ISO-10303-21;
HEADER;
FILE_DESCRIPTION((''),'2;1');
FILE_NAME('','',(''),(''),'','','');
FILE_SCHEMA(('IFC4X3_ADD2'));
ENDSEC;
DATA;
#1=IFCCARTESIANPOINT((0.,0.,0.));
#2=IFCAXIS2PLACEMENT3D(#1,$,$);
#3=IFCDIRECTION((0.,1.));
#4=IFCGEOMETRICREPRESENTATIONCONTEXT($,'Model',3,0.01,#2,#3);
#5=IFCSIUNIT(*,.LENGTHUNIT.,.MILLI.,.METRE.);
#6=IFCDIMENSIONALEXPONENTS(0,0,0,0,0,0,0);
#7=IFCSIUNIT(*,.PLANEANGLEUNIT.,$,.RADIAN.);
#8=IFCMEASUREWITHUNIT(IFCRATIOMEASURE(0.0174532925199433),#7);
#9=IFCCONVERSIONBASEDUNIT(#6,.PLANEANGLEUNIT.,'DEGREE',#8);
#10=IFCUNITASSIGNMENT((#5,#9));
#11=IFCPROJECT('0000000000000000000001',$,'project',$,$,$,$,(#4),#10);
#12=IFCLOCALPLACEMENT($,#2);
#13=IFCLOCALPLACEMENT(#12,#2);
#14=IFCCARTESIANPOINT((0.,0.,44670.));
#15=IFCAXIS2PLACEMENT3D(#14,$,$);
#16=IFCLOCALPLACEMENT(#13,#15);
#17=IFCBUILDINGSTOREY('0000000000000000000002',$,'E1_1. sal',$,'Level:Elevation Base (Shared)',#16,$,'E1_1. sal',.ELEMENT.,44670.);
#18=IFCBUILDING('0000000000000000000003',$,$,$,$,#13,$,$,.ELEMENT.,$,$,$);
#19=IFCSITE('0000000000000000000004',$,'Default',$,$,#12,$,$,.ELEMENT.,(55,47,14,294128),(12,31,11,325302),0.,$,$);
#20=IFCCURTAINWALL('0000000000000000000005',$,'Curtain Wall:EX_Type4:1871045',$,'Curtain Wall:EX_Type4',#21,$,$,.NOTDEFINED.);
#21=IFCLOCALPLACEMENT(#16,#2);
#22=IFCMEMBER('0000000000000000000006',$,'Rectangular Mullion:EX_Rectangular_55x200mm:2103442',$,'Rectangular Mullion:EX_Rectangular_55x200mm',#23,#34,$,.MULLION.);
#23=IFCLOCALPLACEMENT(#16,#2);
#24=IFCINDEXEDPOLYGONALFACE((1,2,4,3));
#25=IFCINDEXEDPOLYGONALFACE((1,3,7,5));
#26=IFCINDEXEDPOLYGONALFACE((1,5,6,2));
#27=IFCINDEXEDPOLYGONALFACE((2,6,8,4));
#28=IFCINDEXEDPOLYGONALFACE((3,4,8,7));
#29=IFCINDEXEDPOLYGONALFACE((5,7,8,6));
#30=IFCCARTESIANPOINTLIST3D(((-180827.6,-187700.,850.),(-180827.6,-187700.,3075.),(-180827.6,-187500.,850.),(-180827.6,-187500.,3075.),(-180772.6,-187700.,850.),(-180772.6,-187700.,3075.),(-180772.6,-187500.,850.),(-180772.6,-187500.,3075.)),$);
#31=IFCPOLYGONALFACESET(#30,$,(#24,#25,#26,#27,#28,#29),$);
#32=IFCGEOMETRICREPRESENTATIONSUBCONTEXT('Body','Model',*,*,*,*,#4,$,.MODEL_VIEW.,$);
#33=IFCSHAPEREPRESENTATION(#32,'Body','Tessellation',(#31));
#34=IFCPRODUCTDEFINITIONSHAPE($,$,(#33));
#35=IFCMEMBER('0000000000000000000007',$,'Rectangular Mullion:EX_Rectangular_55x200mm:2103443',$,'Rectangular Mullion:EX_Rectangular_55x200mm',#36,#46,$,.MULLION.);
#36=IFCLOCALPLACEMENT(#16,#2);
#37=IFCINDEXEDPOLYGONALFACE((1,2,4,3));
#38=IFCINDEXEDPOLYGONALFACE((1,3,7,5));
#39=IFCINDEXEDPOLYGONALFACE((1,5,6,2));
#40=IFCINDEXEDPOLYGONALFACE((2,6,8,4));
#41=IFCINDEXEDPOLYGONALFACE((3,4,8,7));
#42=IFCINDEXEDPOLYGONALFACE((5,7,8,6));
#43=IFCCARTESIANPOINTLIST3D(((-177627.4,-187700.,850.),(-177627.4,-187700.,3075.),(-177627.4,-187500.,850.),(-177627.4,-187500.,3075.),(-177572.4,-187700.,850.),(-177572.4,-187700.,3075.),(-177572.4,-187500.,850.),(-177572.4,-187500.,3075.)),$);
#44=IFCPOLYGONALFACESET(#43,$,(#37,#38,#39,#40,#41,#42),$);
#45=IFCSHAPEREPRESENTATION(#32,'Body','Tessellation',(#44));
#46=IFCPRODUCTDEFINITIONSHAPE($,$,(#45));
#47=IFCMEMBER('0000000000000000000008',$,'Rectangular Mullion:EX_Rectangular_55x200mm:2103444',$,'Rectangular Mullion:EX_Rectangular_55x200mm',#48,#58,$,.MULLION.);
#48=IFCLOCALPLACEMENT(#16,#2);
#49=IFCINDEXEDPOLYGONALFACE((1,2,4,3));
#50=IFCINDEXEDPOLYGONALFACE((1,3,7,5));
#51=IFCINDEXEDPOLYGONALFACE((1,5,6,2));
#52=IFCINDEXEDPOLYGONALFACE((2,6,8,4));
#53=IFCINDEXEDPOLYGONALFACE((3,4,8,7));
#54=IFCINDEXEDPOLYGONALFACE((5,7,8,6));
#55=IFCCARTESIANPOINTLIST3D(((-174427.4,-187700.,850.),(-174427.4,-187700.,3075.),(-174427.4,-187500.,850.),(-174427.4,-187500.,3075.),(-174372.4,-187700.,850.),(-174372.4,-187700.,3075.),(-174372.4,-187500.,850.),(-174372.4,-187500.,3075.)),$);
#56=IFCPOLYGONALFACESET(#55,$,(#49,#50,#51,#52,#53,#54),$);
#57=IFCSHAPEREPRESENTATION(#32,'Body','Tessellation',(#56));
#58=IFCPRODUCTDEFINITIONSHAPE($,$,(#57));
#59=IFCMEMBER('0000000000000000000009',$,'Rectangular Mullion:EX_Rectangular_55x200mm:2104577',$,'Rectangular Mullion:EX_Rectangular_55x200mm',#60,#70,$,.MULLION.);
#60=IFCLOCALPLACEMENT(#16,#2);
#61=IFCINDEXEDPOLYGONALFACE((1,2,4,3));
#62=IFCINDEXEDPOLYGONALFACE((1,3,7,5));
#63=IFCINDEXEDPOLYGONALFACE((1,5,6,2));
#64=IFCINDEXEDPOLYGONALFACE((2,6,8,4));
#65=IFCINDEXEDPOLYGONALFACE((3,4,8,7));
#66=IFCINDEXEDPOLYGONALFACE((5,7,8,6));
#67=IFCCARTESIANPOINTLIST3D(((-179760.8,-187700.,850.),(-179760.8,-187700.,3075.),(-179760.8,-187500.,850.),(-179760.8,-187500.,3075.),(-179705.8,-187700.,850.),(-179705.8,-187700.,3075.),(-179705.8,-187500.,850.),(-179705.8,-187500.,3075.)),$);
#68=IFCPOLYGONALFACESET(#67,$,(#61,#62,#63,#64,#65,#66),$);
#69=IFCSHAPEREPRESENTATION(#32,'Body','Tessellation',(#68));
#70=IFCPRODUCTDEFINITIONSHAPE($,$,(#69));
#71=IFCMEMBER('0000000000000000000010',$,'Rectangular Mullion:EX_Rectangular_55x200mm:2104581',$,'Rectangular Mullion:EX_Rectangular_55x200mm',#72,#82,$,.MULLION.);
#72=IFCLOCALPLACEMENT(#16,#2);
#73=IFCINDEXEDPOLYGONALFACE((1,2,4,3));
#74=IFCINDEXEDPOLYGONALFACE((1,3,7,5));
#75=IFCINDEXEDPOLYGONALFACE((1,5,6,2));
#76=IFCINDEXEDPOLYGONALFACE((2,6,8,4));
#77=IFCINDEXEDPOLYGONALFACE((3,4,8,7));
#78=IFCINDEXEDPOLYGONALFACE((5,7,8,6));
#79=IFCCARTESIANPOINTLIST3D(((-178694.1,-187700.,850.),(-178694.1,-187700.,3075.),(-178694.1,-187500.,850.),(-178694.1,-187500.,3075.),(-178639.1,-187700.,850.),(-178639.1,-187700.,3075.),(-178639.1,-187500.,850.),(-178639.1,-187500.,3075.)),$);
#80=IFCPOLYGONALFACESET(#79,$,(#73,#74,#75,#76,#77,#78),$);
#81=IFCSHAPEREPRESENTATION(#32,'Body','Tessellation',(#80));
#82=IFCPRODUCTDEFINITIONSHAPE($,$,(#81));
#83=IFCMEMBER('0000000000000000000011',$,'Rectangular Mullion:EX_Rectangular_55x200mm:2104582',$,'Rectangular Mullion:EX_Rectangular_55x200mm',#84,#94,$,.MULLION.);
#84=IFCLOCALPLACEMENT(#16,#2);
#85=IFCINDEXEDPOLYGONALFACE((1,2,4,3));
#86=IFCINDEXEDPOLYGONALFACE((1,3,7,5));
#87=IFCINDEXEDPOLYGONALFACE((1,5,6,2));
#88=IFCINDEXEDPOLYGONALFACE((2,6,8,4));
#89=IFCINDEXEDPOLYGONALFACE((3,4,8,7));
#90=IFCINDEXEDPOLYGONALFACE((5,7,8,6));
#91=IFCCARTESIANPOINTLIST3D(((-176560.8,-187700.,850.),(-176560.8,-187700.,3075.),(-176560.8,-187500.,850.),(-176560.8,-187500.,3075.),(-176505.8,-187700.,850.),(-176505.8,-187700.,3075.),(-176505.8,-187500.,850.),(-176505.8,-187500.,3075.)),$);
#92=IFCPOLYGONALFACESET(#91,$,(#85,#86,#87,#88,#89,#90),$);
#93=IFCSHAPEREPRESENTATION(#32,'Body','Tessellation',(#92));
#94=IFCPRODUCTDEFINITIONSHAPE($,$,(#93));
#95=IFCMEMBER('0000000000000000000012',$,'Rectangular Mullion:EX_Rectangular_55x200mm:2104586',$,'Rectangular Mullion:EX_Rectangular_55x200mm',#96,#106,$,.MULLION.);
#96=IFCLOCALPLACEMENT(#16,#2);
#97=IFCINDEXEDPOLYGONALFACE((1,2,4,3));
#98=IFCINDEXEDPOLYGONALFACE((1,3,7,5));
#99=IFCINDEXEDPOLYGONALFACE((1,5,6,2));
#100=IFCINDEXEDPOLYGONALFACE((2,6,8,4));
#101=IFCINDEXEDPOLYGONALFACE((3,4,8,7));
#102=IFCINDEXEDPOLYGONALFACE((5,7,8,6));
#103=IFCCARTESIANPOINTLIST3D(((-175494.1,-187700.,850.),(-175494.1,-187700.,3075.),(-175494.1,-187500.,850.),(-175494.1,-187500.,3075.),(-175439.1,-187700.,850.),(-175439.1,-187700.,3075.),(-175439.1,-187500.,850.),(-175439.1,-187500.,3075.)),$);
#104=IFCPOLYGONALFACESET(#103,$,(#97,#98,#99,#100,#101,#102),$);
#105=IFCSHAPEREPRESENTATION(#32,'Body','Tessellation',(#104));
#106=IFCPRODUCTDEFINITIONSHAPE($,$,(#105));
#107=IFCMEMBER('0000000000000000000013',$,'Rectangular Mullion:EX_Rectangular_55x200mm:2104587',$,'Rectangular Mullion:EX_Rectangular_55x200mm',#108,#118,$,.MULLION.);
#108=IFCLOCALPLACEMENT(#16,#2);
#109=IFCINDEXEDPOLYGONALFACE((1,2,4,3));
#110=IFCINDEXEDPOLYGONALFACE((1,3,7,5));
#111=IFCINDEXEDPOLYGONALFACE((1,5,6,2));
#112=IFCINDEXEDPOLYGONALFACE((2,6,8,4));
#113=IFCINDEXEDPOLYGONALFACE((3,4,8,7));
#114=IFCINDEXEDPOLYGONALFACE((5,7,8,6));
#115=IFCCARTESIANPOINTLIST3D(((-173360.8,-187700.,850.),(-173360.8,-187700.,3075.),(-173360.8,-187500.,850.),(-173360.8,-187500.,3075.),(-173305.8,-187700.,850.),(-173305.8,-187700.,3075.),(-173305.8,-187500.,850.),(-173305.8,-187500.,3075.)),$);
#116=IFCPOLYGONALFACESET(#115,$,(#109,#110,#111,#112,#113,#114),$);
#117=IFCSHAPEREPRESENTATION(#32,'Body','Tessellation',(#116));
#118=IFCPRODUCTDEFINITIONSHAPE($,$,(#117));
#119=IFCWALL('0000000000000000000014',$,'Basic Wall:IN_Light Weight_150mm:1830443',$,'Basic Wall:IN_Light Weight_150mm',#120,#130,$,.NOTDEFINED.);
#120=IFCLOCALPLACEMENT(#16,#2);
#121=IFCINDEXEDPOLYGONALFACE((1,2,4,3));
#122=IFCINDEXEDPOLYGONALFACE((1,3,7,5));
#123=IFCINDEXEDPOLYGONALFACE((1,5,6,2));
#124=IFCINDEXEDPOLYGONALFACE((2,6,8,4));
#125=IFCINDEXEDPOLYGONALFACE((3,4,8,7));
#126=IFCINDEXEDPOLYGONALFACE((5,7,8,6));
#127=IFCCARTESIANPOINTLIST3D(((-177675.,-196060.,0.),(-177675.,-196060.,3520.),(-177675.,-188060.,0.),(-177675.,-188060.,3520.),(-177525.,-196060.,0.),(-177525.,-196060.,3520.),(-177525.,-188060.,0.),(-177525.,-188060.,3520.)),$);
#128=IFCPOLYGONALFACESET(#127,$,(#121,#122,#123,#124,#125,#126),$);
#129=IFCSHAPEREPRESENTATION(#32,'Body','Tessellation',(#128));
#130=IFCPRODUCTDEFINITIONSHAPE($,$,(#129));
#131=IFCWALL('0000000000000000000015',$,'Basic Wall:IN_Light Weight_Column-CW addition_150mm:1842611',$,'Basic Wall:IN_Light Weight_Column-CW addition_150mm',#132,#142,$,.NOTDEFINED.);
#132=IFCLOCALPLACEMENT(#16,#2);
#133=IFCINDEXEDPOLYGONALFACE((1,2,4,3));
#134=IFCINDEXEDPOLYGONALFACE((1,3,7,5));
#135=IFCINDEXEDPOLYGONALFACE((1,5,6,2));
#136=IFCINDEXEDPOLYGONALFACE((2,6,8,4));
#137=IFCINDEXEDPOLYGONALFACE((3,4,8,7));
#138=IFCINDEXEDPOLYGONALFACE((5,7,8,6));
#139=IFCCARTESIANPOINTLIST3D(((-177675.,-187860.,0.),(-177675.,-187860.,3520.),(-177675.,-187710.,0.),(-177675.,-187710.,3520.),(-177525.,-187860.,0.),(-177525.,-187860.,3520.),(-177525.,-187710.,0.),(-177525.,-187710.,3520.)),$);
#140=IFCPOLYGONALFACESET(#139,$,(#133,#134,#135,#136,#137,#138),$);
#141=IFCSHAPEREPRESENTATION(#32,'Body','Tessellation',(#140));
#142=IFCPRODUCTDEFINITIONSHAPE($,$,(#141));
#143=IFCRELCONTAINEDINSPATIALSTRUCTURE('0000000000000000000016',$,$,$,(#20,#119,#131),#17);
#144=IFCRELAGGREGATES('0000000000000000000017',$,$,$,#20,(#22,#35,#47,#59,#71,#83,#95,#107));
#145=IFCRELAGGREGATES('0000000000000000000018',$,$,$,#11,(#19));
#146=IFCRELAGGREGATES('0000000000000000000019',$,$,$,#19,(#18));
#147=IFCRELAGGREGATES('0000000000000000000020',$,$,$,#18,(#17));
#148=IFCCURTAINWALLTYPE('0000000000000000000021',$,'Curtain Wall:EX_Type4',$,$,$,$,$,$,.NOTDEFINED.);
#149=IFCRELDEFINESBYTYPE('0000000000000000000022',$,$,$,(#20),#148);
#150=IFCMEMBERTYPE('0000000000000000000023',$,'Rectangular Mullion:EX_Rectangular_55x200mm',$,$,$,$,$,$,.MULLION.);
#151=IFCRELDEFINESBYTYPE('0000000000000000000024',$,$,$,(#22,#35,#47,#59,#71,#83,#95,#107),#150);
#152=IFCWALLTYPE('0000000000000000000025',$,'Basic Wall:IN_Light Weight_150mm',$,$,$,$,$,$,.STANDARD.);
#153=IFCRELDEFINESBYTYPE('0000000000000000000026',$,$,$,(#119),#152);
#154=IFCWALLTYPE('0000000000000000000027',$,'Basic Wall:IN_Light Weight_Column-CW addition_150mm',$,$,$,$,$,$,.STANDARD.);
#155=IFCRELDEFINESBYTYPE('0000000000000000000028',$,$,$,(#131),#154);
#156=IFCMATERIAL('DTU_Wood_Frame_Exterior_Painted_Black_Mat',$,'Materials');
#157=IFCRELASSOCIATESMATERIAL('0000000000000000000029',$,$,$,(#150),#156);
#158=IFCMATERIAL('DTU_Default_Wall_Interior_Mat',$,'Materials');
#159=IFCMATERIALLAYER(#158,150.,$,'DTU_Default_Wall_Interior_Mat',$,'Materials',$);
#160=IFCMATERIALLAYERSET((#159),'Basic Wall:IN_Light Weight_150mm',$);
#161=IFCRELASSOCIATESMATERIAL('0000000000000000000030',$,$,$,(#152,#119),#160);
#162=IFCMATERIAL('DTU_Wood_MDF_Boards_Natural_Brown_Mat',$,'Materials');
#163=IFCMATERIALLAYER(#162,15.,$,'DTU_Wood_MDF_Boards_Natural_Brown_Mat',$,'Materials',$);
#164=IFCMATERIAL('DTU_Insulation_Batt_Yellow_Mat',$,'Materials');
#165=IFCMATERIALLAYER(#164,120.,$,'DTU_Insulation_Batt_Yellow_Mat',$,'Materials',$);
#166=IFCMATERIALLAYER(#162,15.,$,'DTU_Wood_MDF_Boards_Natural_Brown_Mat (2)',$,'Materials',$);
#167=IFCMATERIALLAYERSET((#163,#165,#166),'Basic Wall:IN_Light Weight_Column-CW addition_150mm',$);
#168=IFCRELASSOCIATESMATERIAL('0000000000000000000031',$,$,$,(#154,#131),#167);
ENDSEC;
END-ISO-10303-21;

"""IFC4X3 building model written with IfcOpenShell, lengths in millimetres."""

from ifc_helpers import new_model, entity, si_unit, converted_unit, direction, frame, frame_2d, origin, origin_2d_with_axis, place, context, subcontext, project, spatial, rectangle, extrude, source, transform, mapped, material, layer, layer_set, material_profile, profile_set, type_object, type_shapes, element, aggregate, save


model = new_model("IFC4X3")

# Units and contexts
model_context = context("Model", 3, precision=0.01, world=origin(), true_north=direction((0.0, 1.0)))
body_context = subcontext(model_context, "Body", "Model", "MODEL_VIEW")
ifc_project = project(units=[si_unit("LENGTHUNIT", "METRE", prefix="MILLI"), converted_unit("PLANEANGLEUNIT", "DEGREE", entity("IfcRatioMeasure", 0.0174532925199433), si_unit("PLANEANGLEUNIT", "RADIAN"), dimensions=[0, 0, 0, 0, 0, 0, 0])], contexts=[model_context])

# Site, building, storey
site_placement = place(None, origin())
site = spatial("IfcSite", under=ifc_project, at=site_placement, Name="Default", CompositionType="ELEMENT", RefLatitude=(55, 47, 14, 294128), RefLongitude=(12, 31, 11, 325302), RefElevation=0.0)
building_placement = place(site_placement, origin())
building = spatial("IfcBuilding", under=site, at=building_placement, CompositionType="ELEMENT")
storey_placement = place(building_placement, frame((0.0, 0.0, 44670.0)))
storey = spatial("IfcBuildingStorey", under=building, at=storey_placement, Name="E1_1. sal", ObjectType="Level:Elevation Base (Shared)", LongName="E1_1. sal", CompositionType="ELEMENT", Elevation=44670.0)

# Curtain wall, members
curtain_wall_type_1 = type_object("IfcCurtainWallType", Name="Curtain Wall:EX_Type4", PredefinedType="NOTDEFINED")
curtain_wall_1_placement = place(storey_placement, frame((0.0, 0.0, -44670.0)))
curtain_wall_1 = element("IfcCurtainWall", 1, at=curtain_wall_1_placement, inside=storey, type_object=curtain_wall_type_1, Name="Curtain Wall:EX_Type4:1871045", ObjectType="Curtain Wall:EX_Type4", PredefinedType="NOTDEFINED")
ifc_material_1 = material(Name="DTU_Wood_Frame_Exterior_Painted_Black_Mat", Category="Materials")
ifc_material_profile = material_profile(ifc_material_1, rectangle(XDim=200.0, YDim=55.0, at=origin_2d_with_axis()), Name="EX_Rectangular_55x200mm")
ifc_profile_set = profile_set([ifc_material_profile], Name="EX_Rectangular_55x200mm")
member_type = type_object("IfcMemberType", Name="Rectangular Mullion:EX_Rectangular_55x200mm", PredefinedType="MULLION", material=ifc_profile_set)
shared_shape_1 = source(origin(), body_context, "Body", "SweptSolid", [
    extrude(rectangle(XDim=200.0, YDim=55.0, at=origin_2d_with_axis()), frame((0.0, -100.0, -2225.0), z_axis=(0.0, 0.0, 1.0), x_axis=(0.0, -1.0, 0.0)), (0.0, 0.0, 1.0), 2225.0),
])
type_shapes(member_type, [shared_shape_1])
member_1_placement = place(curtain_wall_1_placement, frame((-180800.1, -187500.0, 45520.0), z_axis=(0.0, 0.0, -1.0), x_axis=(-1.0, 0.0, 0.0)))
member_1 = element("IfcMember", 2, at=member_1_placement, type_object=member_type, Name="Rectangular Mullion:EX_Rectangular_55x200mm:2103442", ObjectType="Rectangular Mullion:EX_Rectangular_55x200mm", PredefinedType="MULLION", context=body_context, shape_type="MappedRepresentation", body=[
    mapped(shared_shape_1, transform((0.0, 0.0, 0.0), scale=1.0)),
])
member_2_placement = place(curtain_wall_1_placement, frame((-177599.9, -187500.0, 45520.0), z_axis=(0.0, 0.0, -1.0), x_axis=(-1.0, 0.0, 0.0)))
member_2 = element("IfcMember", 3, at=member_2_placement, type_object=member_type, Name="Rectangular Mullion:EX_Rectangular_55x200mm:2103443", ObjectType="Rectangular Mullion:EX_Rectangular_55x200mm", PredefinedType="MULLION", context=body_context, shape_type="MappedRepresentation", body=[
    mapped(shared_shape_1, transform((0.0, 0.0, 0.0), scale=1.0)),
])
member_3_placement = place(curtain_wall_1_placement, frame((-174399.9, -187500.0, 45520.0), z_axis=(0.0, 0.0, -1.0), x_axis=(-1.0, 0.0, 0.0)))
member_3 = element("IfcMember", 4, at=member_3_placement, type_object=member_type, Name="Rectangular Mullion:EX_Rectangular_55x200mm:2103444", ObjectType="Rectangular Mullion:EX_Rectangular_55x200mm", PredefinedType="MULLION", context=body_context, shape_type="MappedRepresentation", body=[
    mapped(shared_shape_1, transform((0.0, 0.0, 0.0), scale=1.0)),
])
member_4_placement = place(curtain_wall_1_placement, frame((-179733.3, -187500.0, 45520.0), z_axis=(0.0, 0.0, -1.0), x_axis=(-1.0, 0.0, 0.0)))
member_4 = element("IfcMember", 5, at=member_4_placement, type_object=member_type, Name="Rectangular Mullion:EX_Rectangular_55x200mm:2104577", ObjectType="Rectangular Mullion:EX_Rectangular_55x200mm", PredefinedType="MULLION", context=body_context, shape_type="MappedRepresentation", body=[
    mapped(shared_shape_1, transform((0.0, 0.0, 0.0), scale=1.0)),
])
member_5_placement = place(curtain_wall_1_placement, frame((-178666.6, -187500.0, 45520.0), z_axis=(0.0, 0.0, -1.0), x_axis=(-1.0, 0.0, 0.0)))
member_5 = element("IfcMember", 6, at=member_5_placement, type_object=member_type, Name="Rectangular Mullion:EX_Rectangular_55x200mm:2104581", ObjectType="Rectangular Mullion:EX_Rectangular_55x200mm", PredefinedType="MULLION", context=body_context, shape_type="MappedRepresentation", body=[
    mapped(shared_shape_1, transform((0.0, 0.0, 0.0), scale=1.0)),
])
member_6_placement = place(curtain_wall_1_placement, frame((-176533.3, -187500.0, 45520.0), z_axis=(0.0, 0.0, -1.0), x_axis=(-1.0, 0.0, 0.0)))
member_6 = element("IfcMember", 7, at=member_6_placement, type_object=member_type, Name="Rectangular Mullion:EX_Rectangular_55x200mm:2104582", ObjectType="Rectangular Mullion:EX_Rectangular_55x200mm", PredefinedType="MULLION", context=body_context, shape_type="MappedRepresentation", body=[
    mapped(shared_shape_1, transform((0.0, 0.0, 0.0), scale=1.0)),
])
member_7_placement = place(curtain_wall_1_placement, frame((-175466.6, -187500.0, 45520.0), z_axis=(0.0, 0.0, -1.0), x_axis=(-1.0, 0.0, 0.0)))
member_7 = element("IfcMember", 8, at=member_7_placement, type_object=member_type, Name="Rectangular Mullion:EX_Rectangular_55x200mm:2104586", ObjectType="Rectangular Mullion:EX_Rectangular_55x200mm", PredefinedType="MULLION", context=body_context, shape_type="MappedRepresentation", body=[
    mapped(shared_shape_1, transform((0.0, 0.0, 0.0), scale=1.0)),
])
member_8_placement = place(curtain_wall_1_placement, frame((-173333.3, -187500.0, 45520.0), z_axis=(0.0, 0.0, -1.0), x_axis=(-1.0, 0.0, 0.0)))
member_8 = element("IfcMember", 9, at=member_8_placement, type_object=member_type, Name="Rectangular Mullion:EX_Rectangular_55x200mm:2104587", ObjectType="Rectangular Mullion:EX_Rectangular_55x200mm", PredefinedType="MULLION", context=body_context, shape_type="MappedRepresentation", body=[
    mapped(shared_shape_1, transform((0.0, 0.0, 0.0), scale=1.0)),
])

# Walls
ifc_material_2 = material(Name="DTU_Default_Wall_Interior_Mat", Category="Materials")
ifc_layer_1 = layer(ifc_material_2, 150.0, Name="DTU_Default_Wall_Interior_Mat", Category="Materials")
ifc_layer_set_1 = layer_set([ifc_layer_1], Name="Basic Wall:IN_Light Weight_150mm")
wall_type_1 = type_object("IfcWallType", Name="Basic Wall:IN_Light Weight_150mm", PredefinedType="STANDARD", material=ifc_layer_set_1)
wall_1_placement = place(storey_placement, frame((-177600.0, -188060.0, 0.0), z_axis=(0.0, 0.0, 1.0), x_axis=(0.0, -1.0, 0.0)))
element("IfcWall", 10, at=wall_1_placement, inside=storey, type_object=wall_type_1, material=ifc_layer_set_1, Name="Basic Wall:IN_Light Weight_150mm:1830443", ObjectType="Basic Wall:IN_Light Weight_150mm", PredefinedType="NOTDEFINED", context=body_context, shape_type="SweptSolid", body=[
    extrude(rectangle(XDim=8000.0, YDim=150.0, at=frame_2d((4000.0, 0.0), x_axis=(-1.0, 0.0))), origin(), (0.0, 0.0, 1.0), 3520.0),
])
ifc_material_3 = material(Name="DTU_Wood_MDF_Boards_Natural_Brown_Mat", Category="Materials")
ifc_layer_2 = layer(ifc_material_3, 15.0, Name="DTU_Wood_MDF_Boards_Natural_Brown_Mat", Category="Materials")
ifc_material_4 = material(Name="DTU_Insulation_Batt_Yellow_Mat", Category="Materials")
ifc_layer_3 = layer(ifc_material_4, 120.0, Name="DTU_Insulation_Batt_Yellow_Mat", Category="Materials")
ifc_layer_4 = layer(ifc_material_3, 15.0, Name="DTU_Wood_MDF_Boards_Natural_Brown_Mat (2)", Category="Materials")
ifc_layer_set_2 = layer_set([ifc_layer_2, ifc_layer_3, ifc_layer_4], Name="Basic Wall:IN_Light Weight_Column-CW addition_150mm")
wall_type_2 = type_object("IfcWallType", Name="Basic Wall:IN_Light Weight_Column-CW addition_150mm", PredefinedType="STANDARD", material=ifc_layer_set_2)
wall_2_placement = place(storey_placement, frame((-177600.0, -187710.0, 0.0), z_axis=(0.0, 0.0, 1.0), x_axis=(0.0, -1.0, 0.0)))
element("IfcWall", 11, at=wall_2_placement, inside=storey, type_object=wall_type_2, material=ifc_layer_set_2, Name="Basic Wall:IN_Light Weight_Column-CW addition_150mm:1842611", ObjectType="Basic Wall:IN_Light Weight_Column-CW addition_150mm", PredefinedType="NOTDEFINED", context=body_context, shape_type="SweptSolid", body=[
    extrude(rectangle(XDim=150.0, YDim=150.0, at=frame_2d((75.0, 0.0), x_axis=(-1.0, 0.0))), origin(), (0.0, 0.0, 1.0), 3520.0),
])

aggregate(curtain_wall_1, [member_1, member_2, member_3, member_4, member_5, member_6, member_7, member_8])

save(model, "model.ifc")
